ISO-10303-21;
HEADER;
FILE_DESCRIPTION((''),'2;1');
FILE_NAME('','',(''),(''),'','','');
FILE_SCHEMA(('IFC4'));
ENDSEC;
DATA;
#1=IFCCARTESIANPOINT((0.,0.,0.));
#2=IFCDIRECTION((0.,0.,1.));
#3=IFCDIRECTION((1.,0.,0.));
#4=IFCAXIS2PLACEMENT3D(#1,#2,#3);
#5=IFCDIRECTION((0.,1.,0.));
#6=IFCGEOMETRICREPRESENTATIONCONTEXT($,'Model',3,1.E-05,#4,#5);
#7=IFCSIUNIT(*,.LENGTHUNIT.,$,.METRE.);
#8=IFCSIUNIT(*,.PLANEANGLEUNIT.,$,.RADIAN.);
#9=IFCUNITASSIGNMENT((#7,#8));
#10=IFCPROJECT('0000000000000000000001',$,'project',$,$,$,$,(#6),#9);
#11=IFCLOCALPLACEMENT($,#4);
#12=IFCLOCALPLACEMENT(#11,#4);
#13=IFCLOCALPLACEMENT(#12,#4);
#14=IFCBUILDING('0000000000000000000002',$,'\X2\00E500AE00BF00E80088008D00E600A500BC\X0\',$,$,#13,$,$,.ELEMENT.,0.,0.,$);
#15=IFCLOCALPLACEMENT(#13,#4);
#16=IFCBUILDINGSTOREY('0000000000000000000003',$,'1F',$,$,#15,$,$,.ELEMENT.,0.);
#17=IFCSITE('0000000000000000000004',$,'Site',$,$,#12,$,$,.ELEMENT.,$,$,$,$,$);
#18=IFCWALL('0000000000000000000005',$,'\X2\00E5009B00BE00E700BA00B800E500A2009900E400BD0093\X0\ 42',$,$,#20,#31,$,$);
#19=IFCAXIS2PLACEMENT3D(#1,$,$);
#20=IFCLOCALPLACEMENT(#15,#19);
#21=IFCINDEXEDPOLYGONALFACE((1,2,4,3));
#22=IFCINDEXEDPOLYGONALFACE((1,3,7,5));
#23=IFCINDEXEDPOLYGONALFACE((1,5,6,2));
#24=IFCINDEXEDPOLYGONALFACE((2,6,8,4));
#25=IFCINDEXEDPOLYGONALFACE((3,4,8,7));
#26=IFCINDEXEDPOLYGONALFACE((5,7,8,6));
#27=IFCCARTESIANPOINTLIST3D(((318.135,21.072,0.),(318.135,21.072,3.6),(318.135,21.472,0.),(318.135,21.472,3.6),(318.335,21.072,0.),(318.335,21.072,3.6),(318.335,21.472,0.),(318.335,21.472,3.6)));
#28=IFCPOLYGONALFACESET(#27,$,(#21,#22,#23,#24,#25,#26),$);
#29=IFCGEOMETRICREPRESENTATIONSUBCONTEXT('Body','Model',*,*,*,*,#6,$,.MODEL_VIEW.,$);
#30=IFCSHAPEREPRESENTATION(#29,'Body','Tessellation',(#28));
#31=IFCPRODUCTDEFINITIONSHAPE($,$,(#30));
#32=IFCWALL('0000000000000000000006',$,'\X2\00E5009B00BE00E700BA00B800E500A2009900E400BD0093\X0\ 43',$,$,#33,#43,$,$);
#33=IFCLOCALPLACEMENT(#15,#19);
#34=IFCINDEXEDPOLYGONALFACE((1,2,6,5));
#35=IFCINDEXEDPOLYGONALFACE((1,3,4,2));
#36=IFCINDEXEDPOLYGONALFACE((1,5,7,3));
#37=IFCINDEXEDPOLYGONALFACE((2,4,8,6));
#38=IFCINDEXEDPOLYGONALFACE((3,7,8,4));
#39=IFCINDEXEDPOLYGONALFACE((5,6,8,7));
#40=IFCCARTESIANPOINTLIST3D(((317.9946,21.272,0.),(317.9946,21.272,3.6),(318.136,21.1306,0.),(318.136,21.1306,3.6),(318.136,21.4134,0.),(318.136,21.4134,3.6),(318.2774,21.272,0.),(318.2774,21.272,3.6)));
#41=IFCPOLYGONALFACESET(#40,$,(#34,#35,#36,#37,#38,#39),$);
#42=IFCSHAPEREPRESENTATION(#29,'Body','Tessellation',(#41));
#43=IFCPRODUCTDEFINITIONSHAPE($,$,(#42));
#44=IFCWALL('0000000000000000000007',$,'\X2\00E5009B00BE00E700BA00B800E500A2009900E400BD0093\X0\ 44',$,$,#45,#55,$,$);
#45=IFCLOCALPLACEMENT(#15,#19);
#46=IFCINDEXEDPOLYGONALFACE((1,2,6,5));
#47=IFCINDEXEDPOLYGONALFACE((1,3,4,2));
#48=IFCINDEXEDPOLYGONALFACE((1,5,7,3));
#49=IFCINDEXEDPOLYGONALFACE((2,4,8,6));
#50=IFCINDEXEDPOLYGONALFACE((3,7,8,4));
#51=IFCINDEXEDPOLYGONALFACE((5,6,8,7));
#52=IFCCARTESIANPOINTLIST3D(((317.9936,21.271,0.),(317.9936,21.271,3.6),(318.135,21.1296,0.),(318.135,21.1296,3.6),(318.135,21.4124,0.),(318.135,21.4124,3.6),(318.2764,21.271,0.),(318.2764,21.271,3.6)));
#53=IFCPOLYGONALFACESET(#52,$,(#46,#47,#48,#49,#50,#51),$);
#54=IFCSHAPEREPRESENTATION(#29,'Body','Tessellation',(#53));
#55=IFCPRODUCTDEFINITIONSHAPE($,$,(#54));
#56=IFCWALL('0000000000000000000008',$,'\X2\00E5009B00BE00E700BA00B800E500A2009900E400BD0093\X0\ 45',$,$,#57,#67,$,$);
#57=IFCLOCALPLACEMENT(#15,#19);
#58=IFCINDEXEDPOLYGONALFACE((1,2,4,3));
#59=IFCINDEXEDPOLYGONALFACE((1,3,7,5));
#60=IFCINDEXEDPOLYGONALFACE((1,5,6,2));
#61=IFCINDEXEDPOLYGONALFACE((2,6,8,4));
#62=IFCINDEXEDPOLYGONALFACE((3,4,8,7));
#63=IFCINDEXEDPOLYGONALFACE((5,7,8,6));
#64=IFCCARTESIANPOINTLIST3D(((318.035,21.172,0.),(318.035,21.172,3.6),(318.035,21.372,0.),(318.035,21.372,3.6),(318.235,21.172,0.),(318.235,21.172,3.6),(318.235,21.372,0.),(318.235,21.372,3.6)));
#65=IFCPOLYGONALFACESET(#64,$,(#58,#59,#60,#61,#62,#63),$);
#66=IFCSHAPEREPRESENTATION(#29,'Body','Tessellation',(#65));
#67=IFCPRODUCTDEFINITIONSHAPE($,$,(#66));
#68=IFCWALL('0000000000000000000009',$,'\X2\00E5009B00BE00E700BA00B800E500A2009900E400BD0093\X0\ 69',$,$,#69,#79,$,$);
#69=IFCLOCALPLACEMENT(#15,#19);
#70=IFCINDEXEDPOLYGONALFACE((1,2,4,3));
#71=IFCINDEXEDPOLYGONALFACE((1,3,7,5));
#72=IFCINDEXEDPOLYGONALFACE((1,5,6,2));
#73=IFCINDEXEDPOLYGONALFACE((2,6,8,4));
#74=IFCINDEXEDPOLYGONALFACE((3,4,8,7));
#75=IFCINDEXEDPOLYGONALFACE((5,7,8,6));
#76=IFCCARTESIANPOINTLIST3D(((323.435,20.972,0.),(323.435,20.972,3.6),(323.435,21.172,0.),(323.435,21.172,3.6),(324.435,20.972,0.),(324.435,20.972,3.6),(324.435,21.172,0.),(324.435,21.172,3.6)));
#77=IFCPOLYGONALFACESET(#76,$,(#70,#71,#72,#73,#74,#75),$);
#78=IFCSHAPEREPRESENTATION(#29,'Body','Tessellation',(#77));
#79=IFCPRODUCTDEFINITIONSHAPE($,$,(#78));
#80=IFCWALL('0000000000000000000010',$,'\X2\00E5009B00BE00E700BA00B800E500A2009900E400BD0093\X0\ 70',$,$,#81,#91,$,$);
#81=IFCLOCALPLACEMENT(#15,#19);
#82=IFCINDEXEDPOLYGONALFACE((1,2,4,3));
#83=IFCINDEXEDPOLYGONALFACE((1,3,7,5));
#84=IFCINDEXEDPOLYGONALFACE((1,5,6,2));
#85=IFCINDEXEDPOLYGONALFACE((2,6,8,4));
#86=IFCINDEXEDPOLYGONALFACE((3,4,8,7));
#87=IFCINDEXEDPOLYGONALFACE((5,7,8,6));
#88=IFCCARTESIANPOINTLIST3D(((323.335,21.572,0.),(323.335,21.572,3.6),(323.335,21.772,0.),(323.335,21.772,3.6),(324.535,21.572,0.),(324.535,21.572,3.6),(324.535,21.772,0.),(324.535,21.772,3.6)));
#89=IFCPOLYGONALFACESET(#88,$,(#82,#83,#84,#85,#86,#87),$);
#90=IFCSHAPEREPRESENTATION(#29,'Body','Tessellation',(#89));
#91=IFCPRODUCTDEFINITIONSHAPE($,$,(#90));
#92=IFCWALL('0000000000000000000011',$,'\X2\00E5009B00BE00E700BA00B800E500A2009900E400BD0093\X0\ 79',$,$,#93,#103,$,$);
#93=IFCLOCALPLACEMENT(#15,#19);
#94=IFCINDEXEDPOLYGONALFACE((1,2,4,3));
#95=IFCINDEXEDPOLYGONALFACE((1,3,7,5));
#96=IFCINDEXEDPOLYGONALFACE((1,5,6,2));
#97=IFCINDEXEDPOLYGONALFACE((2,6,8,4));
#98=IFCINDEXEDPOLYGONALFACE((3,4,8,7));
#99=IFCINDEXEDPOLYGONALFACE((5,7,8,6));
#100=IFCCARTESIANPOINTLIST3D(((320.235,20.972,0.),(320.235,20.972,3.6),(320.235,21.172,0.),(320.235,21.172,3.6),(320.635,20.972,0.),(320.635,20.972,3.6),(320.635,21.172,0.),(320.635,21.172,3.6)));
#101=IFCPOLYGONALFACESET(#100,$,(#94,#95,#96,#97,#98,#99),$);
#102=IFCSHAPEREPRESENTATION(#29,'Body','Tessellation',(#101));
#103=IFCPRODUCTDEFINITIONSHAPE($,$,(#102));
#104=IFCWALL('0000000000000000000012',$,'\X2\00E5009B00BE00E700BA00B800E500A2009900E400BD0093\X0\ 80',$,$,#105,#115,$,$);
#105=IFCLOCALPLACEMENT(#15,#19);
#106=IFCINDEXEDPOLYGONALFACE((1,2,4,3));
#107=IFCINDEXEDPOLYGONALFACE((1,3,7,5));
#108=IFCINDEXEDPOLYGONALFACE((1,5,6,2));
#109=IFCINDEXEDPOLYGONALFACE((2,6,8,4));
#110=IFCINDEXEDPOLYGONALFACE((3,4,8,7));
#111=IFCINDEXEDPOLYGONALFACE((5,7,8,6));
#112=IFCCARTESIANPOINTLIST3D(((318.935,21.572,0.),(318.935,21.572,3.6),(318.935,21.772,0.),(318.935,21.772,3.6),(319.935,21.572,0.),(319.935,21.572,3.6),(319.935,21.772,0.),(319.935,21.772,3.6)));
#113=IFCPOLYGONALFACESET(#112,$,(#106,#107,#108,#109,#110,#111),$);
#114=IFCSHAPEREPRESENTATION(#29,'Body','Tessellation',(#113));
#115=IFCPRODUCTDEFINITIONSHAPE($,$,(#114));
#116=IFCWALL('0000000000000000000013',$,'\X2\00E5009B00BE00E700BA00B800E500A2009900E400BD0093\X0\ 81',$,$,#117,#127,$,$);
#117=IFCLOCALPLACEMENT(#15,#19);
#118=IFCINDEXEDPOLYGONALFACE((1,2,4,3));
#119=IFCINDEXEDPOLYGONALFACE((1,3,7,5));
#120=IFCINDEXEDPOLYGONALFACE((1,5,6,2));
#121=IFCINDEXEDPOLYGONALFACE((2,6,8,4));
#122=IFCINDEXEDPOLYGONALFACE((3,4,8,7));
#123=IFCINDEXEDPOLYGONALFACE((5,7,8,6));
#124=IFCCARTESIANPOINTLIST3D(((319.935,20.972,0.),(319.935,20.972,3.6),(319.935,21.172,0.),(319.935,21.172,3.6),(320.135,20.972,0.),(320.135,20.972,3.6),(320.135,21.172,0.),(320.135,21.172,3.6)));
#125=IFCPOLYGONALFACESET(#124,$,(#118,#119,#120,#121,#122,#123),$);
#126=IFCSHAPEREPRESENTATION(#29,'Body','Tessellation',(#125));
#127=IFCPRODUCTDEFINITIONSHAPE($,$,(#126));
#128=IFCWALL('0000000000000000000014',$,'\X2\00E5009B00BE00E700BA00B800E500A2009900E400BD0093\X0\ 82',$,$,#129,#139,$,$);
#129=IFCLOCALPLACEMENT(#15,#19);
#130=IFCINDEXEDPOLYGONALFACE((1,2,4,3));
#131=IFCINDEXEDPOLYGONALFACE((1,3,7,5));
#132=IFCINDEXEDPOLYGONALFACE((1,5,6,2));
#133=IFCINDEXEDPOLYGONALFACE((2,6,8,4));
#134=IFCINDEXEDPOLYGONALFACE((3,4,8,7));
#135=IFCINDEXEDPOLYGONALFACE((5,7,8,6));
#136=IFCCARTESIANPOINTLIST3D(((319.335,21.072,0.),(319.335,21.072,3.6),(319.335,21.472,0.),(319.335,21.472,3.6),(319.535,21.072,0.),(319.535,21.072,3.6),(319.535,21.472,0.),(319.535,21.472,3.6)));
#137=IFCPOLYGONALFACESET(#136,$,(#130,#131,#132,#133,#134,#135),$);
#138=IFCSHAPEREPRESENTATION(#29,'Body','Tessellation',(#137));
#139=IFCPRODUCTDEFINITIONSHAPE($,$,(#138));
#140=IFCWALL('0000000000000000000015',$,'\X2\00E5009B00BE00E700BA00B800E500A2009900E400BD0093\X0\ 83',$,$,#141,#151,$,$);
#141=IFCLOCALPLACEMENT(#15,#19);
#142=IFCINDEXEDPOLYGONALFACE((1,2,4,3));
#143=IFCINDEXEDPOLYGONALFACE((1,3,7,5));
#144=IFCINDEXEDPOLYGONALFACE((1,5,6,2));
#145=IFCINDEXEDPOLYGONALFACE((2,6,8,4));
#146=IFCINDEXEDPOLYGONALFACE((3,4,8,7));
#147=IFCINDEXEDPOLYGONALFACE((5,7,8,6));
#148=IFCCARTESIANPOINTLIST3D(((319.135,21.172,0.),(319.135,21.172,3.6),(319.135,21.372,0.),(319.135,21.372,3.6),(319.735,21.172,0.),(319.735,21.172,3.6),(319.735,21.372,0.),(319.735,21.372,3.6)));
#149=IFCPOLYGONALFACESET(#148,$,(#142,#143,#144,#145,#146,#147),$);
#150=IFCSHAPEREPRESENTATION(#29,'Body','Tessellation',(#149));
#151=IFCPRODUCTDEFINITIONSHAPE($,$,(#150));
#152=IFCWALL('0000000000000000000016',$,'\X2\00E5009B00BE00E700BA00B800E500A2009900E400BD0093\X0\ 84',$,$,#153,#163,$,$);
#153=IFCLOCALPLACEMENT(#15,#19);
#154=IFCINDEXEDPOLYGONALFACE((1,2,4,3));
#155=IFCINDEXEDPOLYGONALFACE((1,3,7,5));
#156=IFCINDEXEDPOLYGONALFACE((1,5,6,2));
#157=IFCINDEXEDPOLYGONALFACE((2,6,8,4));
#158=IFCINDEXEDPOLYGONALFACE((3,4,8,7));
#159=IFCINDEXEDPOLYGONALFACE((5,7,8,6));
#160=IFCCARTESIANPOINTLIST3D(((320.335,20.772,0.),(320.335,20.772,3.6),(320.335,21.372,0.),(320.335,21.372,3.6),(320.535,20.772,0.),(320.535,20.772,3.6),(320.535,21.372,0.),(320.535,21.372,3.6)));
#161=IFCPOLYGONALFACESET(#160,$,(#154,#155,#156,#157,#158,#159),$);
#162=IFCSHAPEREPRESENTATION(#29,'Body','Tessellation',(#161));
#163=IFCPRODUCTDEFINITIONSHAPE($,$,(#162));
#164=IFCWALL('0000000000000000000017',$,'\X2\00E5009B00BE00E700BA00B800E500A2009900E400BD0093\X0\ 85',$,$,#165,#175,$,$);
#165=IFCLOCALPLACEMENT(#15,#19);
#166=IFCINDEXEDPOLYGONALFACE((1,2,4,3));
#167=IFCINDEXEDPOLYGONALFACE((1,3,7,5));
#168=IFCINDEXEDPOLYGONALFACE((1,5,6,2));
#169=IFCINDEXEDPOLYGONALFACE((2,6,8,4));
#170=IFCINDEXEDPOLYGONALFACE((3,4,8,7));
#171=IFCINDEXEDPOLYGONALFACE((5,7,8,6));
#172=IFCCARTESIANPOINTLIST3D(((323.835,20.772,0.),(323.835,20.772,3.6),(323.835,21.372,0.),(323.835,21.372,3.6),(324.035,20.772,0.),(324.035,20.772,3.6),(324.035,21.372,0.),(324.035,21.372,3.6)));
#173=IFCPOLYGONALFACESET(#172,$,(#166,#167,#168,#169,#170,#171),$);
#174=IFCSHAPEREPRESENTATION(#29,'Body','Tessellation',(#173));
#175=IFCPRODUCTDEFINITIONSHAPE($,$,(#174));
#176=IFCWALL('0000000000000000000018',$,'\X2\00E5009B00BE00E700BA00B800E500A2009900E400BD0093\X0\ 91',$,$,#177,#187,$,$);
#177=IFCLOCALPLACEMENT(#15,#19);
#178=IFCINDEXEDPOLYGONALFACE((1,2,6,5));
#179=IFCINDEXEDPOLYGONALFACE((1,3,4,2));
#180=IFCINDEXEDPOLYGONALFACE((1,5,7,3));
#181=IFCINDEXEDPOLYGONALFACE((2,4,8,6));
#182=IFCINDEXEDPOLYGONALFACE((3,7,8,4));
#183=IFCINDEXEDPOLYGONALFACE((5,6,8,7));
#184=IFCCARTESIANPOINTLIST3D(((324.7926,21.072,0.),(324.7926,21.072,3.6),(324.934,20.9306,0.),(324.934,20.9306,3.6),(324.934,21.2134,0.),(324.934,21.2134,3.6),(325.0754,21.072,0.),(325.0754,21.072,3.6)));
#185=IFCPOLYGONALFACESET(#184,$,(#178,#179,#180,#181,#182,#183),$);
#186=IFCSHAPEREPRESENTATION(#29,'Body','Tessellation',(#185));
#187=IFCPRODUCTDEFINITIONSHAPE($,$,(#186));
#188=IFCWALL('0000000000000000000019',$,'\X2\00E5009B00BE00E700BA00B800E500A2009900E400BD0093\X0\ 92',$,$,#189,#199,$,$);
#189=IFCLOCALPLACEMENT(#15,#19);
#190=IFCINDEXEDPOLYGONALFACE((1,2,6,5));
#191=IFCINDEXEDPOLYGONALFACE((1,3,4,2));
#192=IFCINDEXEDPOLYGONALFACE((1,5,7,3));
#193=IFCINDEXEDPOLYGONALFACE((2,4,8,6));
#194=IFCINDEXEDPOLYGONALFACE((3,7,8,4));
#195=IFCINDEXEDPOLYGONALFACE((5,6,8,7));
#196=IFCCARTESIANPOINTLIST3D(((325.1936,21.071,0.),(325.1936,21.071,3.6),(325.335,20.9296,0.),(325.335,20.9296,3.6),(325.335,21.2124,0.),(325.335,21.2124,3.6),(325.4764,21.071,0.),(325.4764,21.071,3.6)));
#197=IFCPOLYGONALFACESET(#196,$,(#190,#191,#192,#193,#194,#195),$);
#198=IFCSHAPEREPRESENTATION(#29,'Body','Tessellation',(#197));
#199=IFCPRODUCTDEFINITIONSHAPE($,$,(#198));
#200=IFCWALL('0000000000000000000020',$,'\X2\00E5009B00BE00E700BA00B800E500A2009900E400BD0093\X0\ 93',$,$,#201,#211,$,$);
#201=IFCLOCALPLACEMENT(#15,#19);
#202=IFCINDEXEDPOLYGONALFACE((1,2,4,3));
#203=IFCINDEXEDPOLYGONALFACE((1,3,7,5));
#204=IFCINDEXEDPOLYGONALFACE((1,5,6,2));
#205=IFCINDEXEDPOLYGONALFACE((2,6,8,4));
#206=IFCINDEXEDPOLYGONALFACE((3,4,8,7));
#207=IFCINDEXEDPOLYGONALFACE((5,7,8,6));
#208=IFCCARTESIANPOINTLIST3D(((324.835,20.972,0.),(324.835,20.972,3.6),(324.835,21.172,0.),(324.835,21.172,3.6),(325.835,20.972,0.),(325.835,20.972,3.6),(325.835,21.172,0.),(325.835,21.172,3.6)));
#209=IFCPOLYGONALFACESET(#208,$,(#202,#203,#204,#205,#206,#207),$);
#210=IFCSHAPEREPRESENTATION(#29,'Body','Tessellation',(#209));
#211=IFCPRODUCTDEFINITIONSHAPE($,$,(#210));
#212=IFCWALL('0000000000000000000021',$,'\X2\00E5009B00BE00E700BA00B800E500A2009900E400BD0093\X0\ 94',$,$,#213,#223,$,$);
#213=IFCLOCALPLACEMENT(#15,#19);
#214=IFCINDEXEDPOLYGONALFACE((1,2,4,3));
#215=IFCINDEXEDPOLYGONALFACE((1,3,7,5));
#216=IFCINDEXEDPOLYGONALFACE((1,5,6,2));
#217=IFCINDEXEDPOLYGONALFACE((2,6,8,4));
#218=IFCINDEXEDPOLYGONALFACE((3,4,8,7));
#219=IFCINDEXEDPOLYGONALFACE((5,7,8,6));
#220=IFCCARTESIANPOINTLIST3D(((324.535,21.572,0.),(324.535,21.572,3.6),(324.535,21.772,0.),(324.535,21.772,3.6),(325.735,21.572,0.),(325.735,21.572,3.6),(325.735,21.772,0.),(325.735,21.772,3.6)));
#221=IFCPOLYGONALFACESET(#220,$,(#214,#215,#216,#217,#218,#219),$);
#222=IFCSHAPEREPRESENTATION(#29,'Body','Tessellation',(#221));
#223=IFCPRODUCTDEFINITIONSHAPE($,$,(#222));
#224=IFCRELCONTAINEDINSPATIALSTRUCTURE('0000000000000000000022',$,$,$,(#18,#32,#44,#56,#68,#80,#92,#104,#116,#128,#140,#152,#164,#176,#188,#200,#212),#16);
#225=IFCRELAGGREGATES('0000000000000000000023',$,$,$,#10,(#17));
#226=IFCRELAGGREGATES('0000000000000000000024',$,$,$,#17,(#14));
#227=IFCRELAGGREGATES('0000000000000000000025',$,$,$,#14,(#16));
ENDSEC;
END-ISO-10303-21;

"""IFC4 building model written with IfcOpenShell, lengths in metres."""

from ifc_helpers import new_model, si_unit, direction, frame, frame_2d, origin_with_axes, place, context, subcontext, project, spatial, rectangle, extrude, element, save


model = new_model("IFC4")

# Units and contexts
model_context = context("Model", 3, precision=1e-05, world=origin_with_axes(), true_north=direction((0.0, 1.0, 0.0)))
body_context = subcontext(model_context, "Body", "Model", "MODEL_VIEW")
ifc_project = project(units=[si_unit("LENGTHUNIT", "METRE"), si_unit("PLANEANGLEUNIT", "RADIAN")], contexts=[model_context])

# Site, building, storey
placement = place(None, origin_with_axes())
site_placement = place(placement, origin_with_axes())
site = spatial("IfcSite", under=ifc_project, at=site_placement, Name="Site", CompositionType="ELEMENT")
building_placement = place(site_placement, origin_with_axes())
building = spatial("IfcBuilding", under=site, at=building_placement, Name="å®¿è\u0088\u008dæ¥¼", CompositionType="ELEMENT", ElevationOfRefHeight=0.0, ElevationOfTerrain=0.0)
storey_placement = place(building_placement, origin_with_axes())
storey = spatial("IfcBuildingStorey", under=building, at=storey_placement, Name="1F", CompositionType="ELEMENT", Elevation=0.0)

# Walls
wall_1_placement = place(storey_placement, frame((318.235, 21.272, 0.0), z_axis=(0.0, 0.0, 1.0), x_axis=(0.0, 1.0, 0.0)))
element("IfcWall", 1, at=wall_1_placement, inside=storey, Name="å\u009b¾çº¸å¢\u0099ä½\u0093 42", context=body_context, shape_type="SweptSolid", body=[
    extrude(rectangle(XDim=0.4, YDim=0.2, at=frame_2d((0.0, 0.0), x_axis=(1.0, 0.0, 0.0))), frame((0.0, 0.0, 0.0), z_axis=(0.0, 0.0, 1.0)), (0.0, 0.0, 1.0), 3.6),
])
for number, where, z_axis, x_axis, name in (
    (2, (318.136, 21.272, 0.0), (0.0, 0.0, 1.0), (-0.707107, -0.707107, 0.0), "å\u009b¾çº¸å¢\u0099ä½\u0093 43"),
    (3, (318.135, 21.271, 0.0), (0.0, 0.0, 1.0), (0.707107, 0.707107, 0.0), "å\u009b¾çº¸å¢\u0099ä½\u0093 44"),
    (4, (318.135, 21.272, 0.0), (0.0, 0.0, 1.0), (1.0, 0.0, 0.0), "å\u009b¾çº¸å¢\u0099ä½\u0093 45"),
):
    element("IfcWall", number, at=place(storey_placement, frame(where, z_axis=z_axis, x_axis=x_axis)), inside=storey, Name=name, context=body_context, shape_type="SweptSolid", body=[
        extrude(rectangle(XDim=0.2, YDim=0.2, at=frame_2d((0.0, 0.0), x_axis=(1.0, 0.0, 0.0))), frame((0.0, 0.0, 0.0), z_axis=(0.0, 0.0, 1.0)), (0.0, 0.0, 1.0), 3.6),
    ])
wall_2_placement = place(storey_placement, frame((323.935, 21.072, 0.0), z_axis=(0.0, 0.0, 1.0), x_axis=(1.0, 0.0, 0.0)))
element("IfcWall", 5, at=wall_2_placement, inside=storey, Name="å\u009b¾çº¸å¢\u0099ä½\u0093 69", context=body_context, shape_type="SweptSolid", body=[
    extrude(rectangle(XDim=1.0, YDim=0.2, at=frame_2d((0.0, 0.0), x_axis=(1.0, 0.0, 0.0))), frame((0.0, 0.0, 0.0), z_axis=(0.0, 0.0, 1.0)), (0.0, 0.0, 1.0), 3.6),
])
wall_3_placement = place(storey_placement, frame((323.935, 21.672, 0.0), z_axis=(0.0, 0.0, 1.0), x_axis=(1.0, 0.0, 0.0)))
element("IfcWall", 6, at=wall_3_placement, inside=storey, Name="å\u009b¾çº¸å¢\u0099ä½\u0093 70", context=body_context, shape_type="SweptSolid", body=[
    extrude(rectangle(XDim=1.2, YDim=0.2, at=frame_2d((0.0, 0.0), x_axis=(1.0, 0.0, 0.0))), frame((0.0, 0.0, 0.0), z_axis=(0.0, 0.0, 1.0)), (0.0, 0.0, 1.0), 3.6),
])
wall_4_placement = place(storey_placement, frame((320.435, 21.072, 0.0), z_axis=(0.0, 0.0, 1.0), x_axis=(-1.0, 0.0, 0.0)))
element("IfcWall", 7, at=wall_4_placement, inside=storey, Name="å\u009b¾çº¸å¢\u0099ä½\u0093 79", context=body_context, shape_type="SweptSolid", body=[
    extrude(rectangle(XDim=0.4, YDim=0.2, at=frame_2d((0.0, 0.0), x_axis=(1.0, 0.0, 0.0))), frame((0.0, 0.0, 0.0), z_axis=(0.0, 0.0, 1.0)), (0.0, 0.0, 1.0), 3.6),
])
wall_5_placement = place(storey_placement, frame((319.435, 21.672, 0.0), z_axis=(0.0, 0.0, 1.0), x_axis=(1.0, 0.0, 0.0)))
element("IfcWall", 8, at=wall_5_placement, inside=storey, Name="å\u009b¾çº¸å¢\u0099ä½\u0093 80", context=body_context, shape_type="SweptSolid", body=[
    extrude(rectangle(XDim=1.0, YDim=0.2, at=frame_2d((0.0, 0.0), x_axis=(1.0, 0.0, 0.0))), frame((0.0, 0.0, 0.0), z_axis=(0.0, 0.0, 1.0)), (0.0, 0.0, 1.0), 3.6),
])
wall_6_placement = place(storey_placement, frame((320.035, 21.072, 0.0), z_axis=(0.0, 0.0, 1.0), x_axis=(0.0, 1.0, 0.0)))
element("IfcWall", 9, at=wall_6_placement, inside=storey, Name="å\u009b¾çº¸å¢\u0099ä½\u0093 81", context=body_context, shape_type="SweptSolid", body=[
    extrude(rectangle(XDim=0.2, YDim=0.2, at=frame_2d((0.0, 0.0), x_axis=(1.0, 0.0, 0.0))), frame((0.0, 0.0, 0.0), z_axis=(0.0, 0.0, 1.0)), (0.0, 0.0, 1.0), 3.6),
])
wall_7_placement = place(storey_placement, frame((319.435, 21.272, 0.0), z_axis=(0.0, 0.0, 1.0), x_axis=(0.0, 1.0, 0.0)))
element("IfcWall", 10, at=wall_7_placement, inside=storey, Name="å\u009b¾çº¸å¢\u0099ä½\u0093 82", context=body_context, shape_type="SweptSolid", body=[
    extrude(rectangle(XDim=0.4, YDim=0.2, at=frame_2d((0.0, 0.0), x_axis=(1.0, 0.0, 0.0))), frame((0.0, 0.0, 0.0), z_axis=(0.0, 0.0, 1.0)), (0.0, 0.0, 1.0), 3.6),
])
for number, where, z_axis, x_axis, name in (
    (11, (319.435, 21.272, 0.0), (0.0, 0.0, 1.0), (1.0, 0.0, 0.0), "å\u009b¾çº¸å¢\u0099ä½\u0093 83"),
    (12, (320.435, 21.072, 0.0), (0.0, 0.0, 1.0), (0.0, 1.0, 0.0), "å\u009b¾çº¸å¢\u0099ä½\u0093 84"),
    (13, (323.935, 21.072, 0.0), (0.0, 0.0, 1.0), (0.0, 1.0, 0.0), "å\u009b¾çº¸å¢\u0099ä½\u0093 85"),
):
    element("IfcWall", number, at=place(storey_placement, frame(where, z_axis=z_axis, x_axis=x_axis)), inside=storey, Name=name, context=body_context, shape_type="SweptSolid", body=[
        extrude(rectangle(XDim=0.6, YDim=0.2, at=frame_2d((0.0, 0.0), x_axis=(1.0, 0.0, 0.0))), frame((0.0, 0.0, 0.0), z_axis=(0.0, 0.0, 1.0)), (0.0, 0.0, 1.0), 3.6),
    ])
for number, where, z_axis, x_axis, name in (
    (14, (324.934, 21.072, 0.0), (0.0, 0.0, 1.0), (0.707107, -0.707107, 0.0), "å\u009b¾çº¸å¢\u0099ä½\u0093 91"),
    (15, (325.335, 21.071, 0.0), (0.0, 0.0, 1.0), (0.707107, 0.707107, 0.0), "å\u009b¾çº¸å¢\u0099ä½\u0093 92"),
):
    element("IfcWall", number, at=place(storey_placement, frame(where, z_axis=z_axis, x_axis=x_axis)), inside=storey, Name=name, context=body_context, shape_type="SweptSolid", body=[
        extrude(rectangle(XDim=0.2, YDim=0.2, at=frame_2d((0.0, 0.0), x_axis=(1.0, 0.0, 0.0))), frame((0.0, 0.0, 0.0), z_axis=(0.0, 0.0, 1.0)), (0.0, 0.0, 1.0), 3.6),
    ])
wall_8_placement = place(storey_placement, frame((325.335, 21.072, 0.0), z_axis=(0.0, 0.0, 1.0), x_axis=(1.0, 0.0, 0.0)))
element("IfcWall", 16, at=wall_8_placement, inside=storey, Name="å\u009b¾çº¸å¢\u0099ä½\u0093 93", context=body_context, shape_type="SweptSolid", body=[
    extrude(rectangle(XDim=1.0, YDim=0.2, at=frame_2d((0.0, 0.0), x_axis=(1.0, 0.0, 0.0))), frame((0.0, 0.0, 0.0), z_axis=(0.0, 0.0, 1.0)), (0.0, 0.0, 1.0), 3.6),
])
wall_9_placement = place(storey_placement, frame((325.135, 21.672, 0.0), z_axis=(0.0, 0.0, 1.0), x_axis=(1.0, 0.0, 0.0)))
element("IfcWall", 17, at=wall_9_placement, inside=storey, Name="å\u009b¾çº¸å¢\u0099ä½\u0093 94", context=body_context, shape_type="SweptSolid", body=[
    extrude(rectangle(XDim=1.2, YDim=0.2, at=frame_2d((0.0, 0.0), x_axis=(1.0, 0.0, 0.0))), frame((0.0, 0.0, 0.0), z_axis=(0.0, 0.0, 1.0)), (0.0, 0.0, 1.0), 3.6),
])

save(model, "model.ifc")
